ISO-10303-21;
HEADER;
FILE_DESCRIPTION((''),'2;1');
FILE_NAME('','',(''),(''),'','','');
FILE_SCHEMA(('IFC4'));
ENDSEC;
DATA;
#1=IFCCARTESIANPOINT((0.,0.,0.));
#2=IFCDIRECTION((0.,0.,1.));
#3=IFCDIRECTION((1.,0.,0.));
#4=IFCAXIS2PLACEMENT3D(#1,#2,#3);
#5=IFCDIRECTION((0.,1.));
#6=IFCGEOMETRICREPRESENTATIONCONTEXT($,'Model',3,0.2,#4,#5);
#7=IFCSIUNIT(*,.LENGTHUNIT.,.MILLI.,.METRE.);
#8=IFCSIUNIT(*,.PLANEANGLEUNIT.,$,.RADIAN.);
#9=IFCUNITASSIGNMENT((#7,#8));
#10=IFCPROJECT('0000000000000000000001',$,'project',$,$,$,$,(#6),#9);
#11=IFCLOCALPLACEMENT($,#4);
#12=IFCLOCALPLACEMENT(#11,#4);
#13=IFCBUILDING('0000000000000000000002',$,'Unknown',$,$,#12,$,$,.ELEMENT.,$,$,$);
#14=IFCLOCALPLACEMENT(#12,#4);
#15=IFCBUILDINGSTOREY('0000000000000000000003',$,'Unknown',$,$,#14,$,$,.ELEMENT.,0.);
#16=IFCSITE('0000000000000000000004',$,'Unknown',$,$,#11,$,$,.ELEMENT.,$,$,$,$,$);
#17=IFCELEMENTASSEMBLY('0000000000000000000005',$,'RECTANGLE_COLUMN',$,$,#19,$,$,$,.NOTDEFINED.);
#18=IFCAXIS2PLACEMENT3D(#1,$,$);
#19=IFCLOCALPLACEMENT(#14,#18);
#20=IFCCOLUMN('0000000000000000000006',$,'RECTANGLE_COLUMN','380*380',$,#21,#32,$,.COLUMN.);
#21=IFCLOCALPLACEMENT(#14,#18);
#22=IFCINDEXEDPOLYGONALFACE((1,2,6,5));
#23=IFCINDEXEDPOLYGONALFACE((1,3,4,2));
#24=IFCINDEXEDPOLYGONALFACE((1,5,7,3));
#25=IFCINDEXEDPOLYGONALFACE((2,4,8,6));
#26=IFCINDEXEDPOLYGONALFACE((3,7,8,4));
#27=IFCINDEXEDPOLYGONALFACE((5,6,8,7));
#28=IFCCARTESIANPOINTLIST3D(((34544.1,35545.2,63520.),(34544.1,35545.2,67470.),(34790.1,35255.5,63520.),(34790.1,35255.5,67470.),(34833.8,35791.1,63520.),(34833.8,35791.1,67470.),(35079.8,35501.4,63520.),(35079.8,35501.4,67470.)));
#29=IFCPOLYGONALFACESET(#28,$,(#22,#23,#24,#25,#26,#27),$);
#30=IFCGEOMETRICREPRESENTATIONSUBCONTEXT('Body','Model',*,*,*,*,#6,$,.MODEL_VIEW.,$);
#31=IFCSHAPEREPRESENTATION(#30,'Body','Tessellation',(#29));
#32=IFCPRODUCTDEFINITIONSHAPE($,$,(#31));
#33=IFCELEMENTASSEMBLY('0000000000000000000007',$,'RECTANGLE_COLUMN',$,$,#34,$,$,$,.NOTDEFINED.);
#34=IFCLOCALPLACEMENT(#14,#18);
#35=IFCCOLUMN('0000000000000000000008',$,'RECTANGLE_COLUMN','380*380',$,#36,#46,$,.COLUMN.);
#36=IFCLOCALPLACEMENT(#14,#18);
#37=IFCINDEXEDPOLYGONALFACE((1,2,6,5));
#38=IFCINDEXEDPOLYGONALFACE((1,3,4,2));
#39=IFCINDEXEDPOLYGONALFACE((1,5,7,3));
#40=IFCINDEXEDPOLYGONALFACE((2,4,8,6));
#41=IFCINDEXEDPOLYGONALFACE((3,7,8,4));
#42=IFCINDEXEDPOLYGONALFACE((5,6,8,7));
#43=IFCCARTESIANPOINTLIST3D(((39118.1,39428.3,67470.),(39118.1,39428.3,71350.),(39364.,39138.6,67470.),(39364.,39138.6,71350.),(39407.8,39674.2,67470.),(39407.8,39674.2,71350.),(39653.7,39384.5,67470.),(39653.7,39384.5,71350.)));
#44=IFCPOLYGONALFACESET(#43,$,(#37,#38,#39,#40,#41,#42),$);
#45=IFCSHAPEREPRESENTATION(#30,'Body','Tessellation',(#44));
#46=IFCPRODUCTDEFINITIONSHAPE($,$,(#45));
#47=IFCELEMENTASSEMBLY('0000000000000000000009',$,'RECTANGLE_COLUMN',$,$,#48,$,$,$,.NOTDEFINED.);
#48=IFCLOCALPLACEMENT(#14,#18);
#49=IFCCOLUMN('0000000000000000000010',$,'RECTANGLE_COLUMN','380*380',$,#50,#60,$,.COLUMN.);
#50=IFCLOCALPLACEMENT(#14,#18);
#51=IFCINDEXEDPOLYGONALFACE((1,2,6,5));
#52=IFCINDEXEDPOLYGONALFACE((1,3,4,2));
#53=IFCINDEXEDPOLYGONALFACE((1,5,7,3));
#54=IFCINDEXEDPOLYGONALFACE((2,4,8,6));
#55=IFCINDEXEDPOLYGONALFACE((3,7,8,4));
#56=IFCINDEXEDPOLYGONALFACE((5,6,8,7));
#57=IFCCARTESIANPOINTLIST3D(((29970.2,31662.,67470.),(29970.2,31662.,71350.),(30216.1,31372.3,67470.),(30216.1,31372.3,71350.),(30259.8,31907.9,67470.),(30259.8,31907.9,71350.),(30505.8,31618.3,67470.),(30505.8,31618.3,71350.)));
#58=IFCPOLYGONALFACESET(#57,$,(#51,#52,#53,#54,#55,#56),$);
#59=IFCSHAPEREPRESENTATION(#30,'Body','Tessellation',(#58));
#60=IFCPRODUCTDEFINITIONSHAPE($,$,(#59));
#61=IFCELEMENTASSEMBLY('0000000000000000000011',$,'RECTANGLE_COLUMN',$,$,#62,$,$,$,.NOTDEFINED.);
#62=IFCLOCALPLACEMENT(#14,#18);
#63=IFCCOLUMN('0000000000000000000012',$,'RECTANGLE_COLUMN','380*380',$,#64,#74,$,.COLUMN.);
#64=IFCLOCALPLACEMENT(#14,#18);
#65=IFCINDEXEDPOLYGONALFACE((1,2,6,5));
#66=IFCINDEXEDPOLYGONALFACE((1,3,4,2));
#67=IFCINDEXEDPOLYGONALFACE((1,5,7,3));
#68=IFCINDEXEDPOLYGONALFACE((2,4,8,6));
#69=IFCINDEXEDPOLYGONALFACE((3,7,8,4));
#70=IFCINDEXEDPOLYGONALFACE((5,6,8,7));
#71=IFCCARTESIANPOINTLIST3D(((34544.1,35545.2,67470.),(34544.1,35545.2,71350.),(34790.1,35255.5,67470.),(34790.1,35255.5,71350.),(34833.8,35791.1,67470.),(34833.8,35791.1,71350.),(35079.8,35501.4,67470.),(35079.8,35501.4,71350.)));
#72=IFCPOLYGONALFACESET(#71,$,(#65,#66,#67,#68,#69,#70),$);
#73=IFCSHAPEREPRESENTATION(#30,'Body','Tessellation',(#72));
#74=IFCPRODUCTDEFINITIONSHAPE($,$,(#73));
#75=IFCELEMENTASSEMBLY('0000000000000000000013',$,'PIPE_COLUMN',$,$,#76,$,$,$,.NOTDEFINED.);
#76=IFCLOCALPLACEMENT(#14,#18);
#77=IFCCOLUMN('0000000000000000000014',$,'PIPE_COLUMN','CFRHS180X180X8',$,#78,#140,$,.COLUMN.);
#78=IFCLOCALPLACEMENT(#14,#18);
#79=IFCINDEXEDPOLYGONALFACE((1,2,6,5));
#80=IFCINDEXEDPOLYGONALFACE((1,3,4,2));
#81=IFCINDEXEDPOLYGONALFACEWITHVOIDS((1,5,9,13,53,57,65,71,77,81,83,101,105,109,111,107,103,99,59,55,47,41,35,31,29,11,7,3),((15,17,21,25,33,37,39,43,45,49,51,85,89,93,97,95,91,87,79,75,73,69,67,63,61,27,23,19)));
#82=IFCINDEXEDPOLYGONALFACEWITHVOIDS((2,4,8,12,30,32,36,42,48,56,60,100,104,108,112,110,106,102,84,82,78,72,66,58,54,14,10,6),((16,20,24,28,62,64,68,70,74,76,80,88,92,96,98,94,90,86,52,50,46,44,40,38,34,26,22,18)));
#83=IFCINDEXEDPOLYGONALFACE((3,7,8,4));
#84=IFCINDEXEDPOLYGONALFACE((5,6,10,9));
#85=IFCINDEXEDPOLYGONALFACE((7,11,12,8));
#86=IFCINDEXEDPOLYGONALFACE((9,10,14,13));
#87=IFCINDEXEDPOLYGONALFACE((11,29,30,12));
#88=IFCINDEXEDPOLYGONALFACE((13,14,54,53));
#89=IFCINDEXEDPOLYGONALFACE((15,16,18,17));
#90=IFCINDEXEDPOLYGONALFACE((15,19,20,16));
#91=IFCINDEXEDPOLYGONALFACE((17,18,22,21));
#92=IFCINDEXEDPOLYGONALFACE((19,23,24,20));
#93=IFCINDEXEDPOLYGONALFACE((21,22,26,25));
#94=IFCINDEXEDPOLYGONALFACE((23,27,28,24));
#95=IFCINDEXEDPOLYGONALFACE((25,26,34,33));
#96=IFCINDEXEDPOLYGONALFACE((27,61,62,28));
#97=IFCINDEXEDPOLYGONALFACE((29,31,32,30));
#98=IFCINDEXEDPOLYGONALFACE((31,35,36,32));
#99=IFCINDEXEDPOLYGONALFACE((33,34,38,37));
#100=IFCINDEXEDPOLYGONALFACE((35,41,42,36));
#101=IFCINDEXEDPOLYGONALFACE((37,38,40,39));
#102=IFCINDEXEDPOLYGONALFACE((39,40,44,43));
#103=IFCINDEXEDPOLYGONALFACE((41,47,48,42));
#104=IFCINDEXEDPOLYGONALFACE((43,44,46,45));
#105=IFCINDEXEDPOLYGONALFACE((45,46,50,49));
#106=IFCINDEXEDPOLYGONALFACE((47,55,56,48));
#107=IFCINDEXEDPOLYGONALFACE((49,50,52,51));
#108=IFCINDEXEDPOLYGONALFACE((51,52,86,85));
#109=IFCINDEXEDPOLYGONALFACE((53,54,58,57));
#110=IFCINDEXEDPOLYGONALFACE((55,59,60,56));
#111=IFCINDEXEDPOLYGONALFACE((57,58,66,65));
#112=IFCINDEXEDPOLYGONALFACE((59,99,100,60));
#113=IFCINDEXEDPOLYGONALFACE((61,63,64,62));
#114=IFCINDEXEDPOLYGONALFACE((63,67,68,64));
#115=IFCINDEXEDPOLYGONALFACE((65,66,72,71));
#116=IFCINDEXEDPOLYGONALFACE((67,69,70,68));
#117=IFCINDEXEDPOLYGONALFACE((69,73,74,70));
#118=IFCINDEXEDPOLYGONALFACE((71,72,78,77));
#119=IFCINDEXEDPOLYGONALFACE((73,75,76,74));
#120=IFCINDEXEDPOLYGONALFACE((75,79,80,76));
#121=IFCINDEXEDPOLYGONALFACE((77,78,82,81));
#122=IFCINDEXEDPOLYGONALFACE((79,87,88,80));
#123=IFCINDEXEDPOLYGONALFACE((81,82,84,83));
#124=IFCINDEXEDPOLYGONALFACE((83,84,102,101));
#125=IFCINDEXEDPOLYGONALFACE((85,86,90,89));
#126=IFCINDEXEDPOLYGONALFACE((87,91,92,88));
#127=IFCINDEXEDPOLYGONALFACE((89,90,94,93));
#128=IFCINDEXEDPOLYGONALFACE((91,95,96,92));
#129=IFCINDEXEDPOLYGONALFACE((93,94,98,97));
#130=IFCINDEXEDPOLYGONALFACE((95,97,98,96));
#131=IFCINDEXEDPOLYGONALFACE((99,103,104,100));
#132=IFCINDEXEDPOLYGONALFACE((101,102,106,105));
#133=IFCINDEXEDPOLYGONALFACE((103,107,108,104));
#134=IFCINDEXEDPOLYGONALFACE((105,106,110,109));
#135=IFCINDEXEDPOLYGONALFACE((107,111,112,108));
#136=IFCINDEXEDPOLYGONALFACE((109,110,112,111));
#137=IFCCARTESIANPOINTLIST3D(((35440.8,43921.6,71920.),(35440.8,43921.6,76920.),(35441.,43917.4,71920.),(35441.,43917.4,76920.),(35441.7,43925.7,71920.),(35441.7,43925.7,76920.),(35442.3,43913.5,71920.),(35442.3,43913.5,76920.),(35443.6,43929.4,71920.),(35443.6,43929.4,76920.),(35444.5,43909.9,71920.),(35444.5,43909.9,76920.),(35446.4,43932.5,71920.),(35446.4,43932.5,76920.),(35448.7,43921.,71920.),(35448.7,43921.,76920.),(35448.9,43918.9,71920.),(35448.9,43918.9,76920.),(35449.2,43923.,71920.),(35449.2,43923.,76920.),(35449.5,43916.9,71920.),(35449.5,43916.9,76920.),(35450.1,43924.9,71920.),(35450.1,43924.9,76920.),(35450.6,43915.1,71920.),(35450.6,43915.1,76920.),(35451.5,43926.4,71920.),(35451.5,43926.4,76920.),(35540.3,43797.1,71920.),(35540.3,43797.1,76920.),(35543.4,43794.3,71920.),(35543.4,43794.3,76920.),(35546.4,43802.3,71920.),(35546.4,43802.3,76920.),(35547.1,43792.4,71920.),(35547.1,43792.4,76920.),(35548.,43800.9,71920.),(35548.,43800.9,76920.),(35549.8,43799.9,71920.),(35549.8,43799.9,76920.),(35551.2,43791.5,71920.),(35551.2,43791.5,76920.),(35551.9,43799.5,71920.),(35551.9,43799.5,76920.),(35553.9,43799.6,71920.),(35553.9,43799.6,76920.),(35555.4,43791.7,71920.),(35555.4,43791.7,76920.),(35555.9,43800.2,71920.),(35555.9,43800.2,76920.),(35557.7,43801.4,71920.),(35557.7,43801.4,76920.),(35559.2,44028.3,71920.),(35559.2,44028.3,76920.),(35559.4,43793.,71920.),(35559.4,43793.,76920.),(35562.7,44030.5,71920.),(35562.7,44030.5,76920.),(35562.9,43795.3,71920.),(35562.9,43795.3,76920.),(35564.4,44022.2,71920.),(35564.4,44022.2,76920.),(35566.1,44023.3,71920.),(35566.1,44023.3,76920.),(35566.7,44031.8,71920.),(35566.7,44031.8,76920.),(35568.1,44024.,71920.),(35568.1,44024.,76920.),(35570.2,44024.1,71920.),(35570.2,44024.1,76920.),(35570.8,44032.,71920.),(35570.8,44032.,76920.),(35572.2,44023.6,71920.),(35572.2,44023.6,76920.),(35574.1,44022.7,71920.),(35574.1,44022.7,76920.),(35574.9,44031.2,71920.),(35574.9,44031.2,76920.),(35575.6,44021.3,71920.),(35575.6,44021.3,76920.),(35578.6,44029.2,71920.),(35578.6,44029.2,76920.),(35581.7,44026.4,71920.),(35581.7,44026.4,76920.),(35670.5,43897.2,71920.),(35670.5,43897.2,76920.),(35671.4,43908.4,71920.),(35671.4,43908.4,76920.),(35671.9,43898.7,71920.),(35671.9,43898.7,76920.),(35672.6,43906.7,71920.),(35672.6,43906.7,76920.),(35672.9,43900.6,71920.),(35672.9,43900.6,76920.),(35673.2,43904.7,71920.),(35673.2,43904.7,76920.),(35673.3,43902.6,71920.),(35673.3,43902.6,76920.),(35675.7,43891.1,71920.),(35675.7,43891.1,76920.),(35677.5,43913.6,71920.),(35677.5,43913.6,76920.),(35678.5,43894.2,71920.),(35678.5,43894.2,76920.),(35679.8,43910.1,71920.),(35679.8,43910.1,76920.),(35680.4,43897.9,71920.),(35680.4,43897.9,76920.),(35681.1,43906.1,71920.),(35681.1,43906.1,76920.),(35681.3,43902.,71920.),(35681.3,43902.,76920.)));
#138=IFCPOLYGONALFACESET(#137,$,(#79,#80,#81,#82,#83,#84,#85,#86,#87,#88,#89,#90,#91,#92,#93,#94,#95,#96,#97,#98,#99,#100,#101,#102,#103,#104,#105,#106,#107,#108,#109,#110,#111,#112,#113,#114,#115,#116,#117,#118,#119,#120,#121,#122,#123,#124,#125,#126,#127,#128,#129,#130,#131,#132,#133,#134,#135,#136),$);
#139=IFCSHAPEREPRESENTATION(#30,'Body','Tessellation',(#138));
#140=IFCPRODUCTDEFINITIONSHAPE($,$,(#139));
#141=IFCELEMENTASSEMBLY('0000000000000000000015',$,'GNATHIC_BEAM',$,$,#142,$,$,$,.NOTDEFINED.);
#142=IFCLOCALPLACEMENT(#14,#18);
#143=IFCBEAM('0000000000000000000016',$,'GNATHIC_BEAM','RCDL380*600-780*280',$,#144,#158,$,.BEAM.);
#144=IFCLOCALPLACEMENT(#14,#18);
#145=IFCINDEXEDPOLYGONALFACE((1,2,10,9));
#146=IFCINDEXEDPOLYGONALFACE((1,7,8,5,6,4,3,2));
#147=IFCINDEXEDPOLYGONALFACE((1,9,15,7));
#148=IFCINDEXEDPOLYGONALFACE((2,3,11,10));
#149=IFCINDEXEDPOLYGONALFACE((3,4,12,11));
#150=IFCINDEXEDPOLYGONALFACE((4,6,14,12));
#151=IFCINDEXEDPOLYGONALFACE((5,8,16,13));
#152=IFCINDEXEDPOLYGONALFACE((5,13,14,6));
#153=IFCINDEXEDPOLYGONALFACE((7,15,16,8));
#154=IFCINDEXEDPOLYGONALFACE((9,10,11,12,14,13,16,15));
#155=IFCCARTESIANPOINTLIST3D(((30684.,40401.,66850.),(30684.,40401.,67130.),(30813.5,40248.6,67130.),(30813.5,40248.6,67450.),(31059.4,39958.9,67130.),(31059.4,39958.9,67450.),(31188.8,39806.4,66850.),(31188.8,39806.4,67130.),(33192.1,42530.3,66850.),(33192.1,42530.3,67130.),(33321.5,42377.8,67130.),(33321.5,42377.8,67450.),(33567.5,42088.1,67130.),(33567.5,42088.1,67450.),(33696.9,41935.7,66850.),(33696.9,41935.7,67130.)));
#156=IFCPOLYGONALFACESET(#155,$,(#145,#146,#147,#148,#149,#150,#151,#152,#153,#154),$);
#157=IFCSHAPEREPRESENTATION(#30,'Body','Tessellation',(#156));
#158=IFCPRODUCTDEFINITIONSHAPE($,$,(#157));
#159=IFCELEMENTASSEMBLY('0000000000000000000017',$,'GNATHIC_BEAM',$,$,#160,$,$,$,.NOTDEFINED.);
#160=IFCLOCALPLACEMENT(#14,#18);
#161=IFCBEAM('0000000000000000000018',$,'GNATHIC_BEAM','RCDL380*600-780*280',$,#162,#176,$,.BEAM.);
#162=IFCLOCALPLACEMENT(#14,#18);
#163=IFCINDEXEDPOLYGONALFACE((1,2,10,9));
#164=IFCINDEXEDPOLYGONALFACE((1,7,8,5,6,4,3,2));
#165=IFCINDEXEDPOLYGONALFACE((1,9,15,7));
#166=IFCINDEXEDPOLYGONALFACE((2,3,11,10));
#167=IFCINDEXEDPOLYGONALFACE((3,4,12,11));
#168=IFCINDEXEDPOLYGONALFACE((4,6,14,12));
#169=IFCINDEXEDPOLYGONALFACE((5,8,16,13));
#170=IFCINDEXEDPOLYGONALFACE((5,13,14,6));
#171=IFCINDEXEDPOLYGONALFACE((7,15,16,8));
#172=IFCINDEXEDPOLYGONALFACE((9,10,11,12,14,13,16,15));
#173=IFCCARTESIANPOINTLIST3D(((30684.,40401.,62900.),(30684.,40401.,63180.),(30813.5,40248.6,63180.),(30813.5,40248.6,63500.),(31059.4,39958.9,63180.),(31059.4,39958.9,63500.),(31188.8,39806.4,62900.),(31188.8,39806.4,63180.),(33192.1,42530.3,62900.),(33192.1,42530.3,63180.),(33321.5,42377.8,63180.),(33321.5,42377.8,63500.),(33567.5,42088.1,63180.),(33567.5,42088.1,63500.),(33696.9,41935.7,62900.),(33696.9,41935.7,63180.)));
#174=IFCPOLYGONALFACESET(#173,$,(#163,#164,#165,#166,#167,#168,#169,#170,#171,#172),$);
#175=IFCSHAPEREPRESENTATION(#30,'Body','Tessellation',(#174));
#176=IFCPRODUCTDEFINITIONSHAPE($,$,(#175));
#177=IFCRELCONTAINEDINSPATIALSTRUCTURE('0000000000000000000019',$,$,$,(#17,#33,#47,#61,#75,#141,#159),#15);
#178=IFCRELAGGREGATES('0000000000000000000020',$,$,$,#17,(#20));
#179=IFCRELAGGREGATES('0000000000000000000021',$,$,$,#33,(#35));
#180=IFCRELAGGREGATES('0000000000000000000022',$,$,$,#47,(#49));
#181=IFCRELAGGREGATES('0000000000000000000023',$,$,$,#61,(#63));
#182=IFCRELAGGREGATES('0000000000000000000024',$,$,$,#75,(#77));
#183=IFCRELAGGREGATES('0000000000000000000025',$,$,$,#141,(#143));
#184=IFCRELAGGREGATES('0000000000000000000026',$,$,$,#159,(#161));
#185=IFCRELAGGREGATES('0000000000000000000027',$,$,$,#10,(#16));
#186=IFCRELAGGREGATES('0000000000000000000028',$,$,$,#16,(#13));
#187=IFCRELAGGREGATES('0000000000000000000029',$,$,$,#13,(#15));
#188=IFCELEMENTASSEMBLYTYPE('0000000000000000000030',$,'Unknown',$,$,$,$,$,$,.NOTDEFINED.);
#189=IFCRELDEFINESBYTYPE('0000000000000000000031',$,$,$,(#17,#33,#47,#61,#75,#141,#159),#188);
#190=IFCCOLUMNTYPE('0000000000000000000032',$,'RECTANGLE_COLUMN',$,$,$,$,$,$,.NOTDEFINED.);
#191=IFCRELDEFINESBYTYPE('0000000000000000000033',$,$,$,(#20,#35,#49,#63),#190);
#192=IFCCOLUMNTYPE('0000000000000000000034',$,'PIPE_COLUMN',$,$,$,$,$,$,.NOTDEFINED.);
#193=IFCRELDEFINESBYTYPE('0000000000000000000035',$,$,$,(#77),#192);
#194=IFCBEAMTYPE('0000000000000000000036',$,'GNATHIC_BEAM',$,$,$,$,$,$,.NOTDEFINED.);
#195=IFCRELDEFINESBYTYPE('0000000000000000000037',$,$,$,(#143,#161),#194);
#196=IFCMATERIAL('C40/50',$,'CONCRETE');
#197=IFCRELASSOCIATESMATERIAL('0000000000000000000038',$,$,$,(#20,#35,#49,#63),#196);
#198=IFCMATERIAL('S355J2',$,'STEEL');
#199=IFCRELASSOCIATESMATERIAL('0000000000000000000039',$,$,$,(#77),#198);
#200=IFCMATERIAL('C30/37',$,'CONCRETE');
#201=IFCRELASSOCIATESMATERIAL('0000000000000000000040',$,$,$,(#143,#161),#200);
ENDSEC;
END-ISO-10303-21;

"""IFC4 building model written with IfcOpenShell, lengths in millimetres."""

from ifc_helpers import new_model, si_unit, direction, frame, origin_with_axes, origin_2d_with_axis, place, context, subcontext, project, spatial, polyline, rectangle, hollow_rectangle, outline, extrude, material, material_profile, profile_set, profile_usage, type_object, element, aggregate, save


model = new_model("IFC4")

# Units and contexts
model_context = context("Model", 3, precision=0.2, world=origin_with_axes(), true_north=direction((0.0, 1.0)))
body_context = subcontext(model_context, "Body", "Model", "MODEL_VIEW")
ifc_project = project(units=[si_unit("LENGTHUNIT", "METRE", prefix="MILLI"), si_unit("PLANEANGLEUNIT", "RADIAN")], contexts=[model_context])

# Site, building, storey
site_placement = place(None, origin_with_axes())
site = spatial("IfcSite", under=ifc_project, at=site_placement, Name="Unknown", CompositionType="ELEMENT")
building_placement = place(site_placement, origin_with_axes())
building = spatial("IfcBuilding", under=site, at=building_placement, Name="Unknown", CompositionType="ELEMENT")
storey_placement = place(building_placement, origin_with_axes())
storey = spatial("IfcBuildingStorey", under=building, at=storey_placement, Name="Unknown", CompositionType="ELEMENT", Elevation=0.0)

# Element assemblies, columns
element_assembly_type = type_object("IfcElementAssemblyType", Name="Unknown", PredefinedType="NOTDEFINED")
assembly_1_placement = place(storey_placement, frame((34811.9, 35523.3, 63520.0), z_axis=(-0.762329, -0.64719, 0.0), x_axis=(0.0, 0.0, 1.0)))
assembly_1 = element("IfcElementAssembly", 1, at=assembly_1_placement, inside=storey, type_object=element_assembly_type, Name="RECTANGLE_COLUMN", PredefinedType="NOTDEFINED")
ifc_material_1 = material(Name="C40/50", Category="CONCRETE")
ifc_material_profile_1 = material_profile(ifc_material_1, rectangle(XDim=380.0, YDim=380.0, at=origin_2d_with_axis()), Name="380*380")
ifc_profile_set_1 = profile_set([ifc_material_profile_1])
ifc_profile_usage_1 = profile_usage(ifc_profile_set_1, cardinal=5)
column_type_1 = type_object("IfcColumnType", Name="RECTANGLE_COLUMN")
column_1_placement = place(assembly_1_placement, origin_with_axes())
column_1 = element("IfcColumn", 2, at=column_1_placement, type_object=column_type_1, material=ifc_profile_usage_1, Name="RECTANGLE_COLUMN", Description="380*380", PredefinedType="COLUMN", context=body_context, shape_type="SolidModel", body=[
    extrude(rectangle(XDim=380.0, YDim=380.0, at=origin_2d_with_axis()), frame((0.0, 0.0, 0.0), z_axis=(-1.0, 0.0, 0.0), x_axis=(0.0, 0.0, 1.0)), (0.0, 0.0, -1.0), 3950.0),
])
aggregate(assembly_1, [column_1])
assembly_2_placement = place(storey_placement, frame((39385.9, 39406.4, 67470.0), z_axis=(-0.762329, -0.64719, 0.0), x_axis=(0.0, 0.0, 1.0)))
assembly_2 = element("IfcElementAssembly", 3, at=assembly_2_placement, inside=storey, type_object=element_assembly_type, Name="RECTANGLE_COLUMN", PredefinedType="NOTDEFINED")
column_2_placement = place(assembly_2_placement, origin_with_axes())
column_2 = element("IfcColumn", 4, at=column_2_placement, type_object=column_type_1, material=ifc_profile_usage_1, Name="RECTANGLE_COLUMN", Description="380*380", PredefinedType="COLUMN", context=body_context, shape_type="SolidModel", body=[
    extrude(rectangle(XDim=380.0, YDim=380.0, at=origin_2d_with_axis()), frame((0.0, 0.0, 0.0), z_axis=(-1.0, 0.0, 0.0), x_axis=(0.0, 0.0, 1.0)), (0.0, 0.0, -1.0), 3880.0),
])
aggregate(assembly_2, [column_2])
assembly_3_placement = place(storey_placement, frame((30238.0, 31640.1, 67470.0), z_axis=(-0.762329, -0.64719, 0.0), x_axis=(0.0, 0.0, 1.0)))
assembly_3 = element("IfcElementAssembly", 5, at=assembly_3_placement, inside=storey, type_object=element_assembly_type, Name="RECTANGLE_COLUMN", PredefinedType="NOTDEFINED")
column_3_placement = place(assembly_3_placement, origin_with_axes())
column_3 = element("IfcColumn", 6, at=column_3_placement, type_object=column_type_1, material=ifc_profile_usage_1, Name="RECTANGLE_COLUMN", Description="380*380", PredefinedType="COLUMN", context=body_context, shape_type="SolidModel", body=[
    extrude(rectangle(XDim=380.0, YDim=380.0, at=origin_2d_with_axis()), frame((0.0, 0.0, 0.0), z_axis=(-1.0, 0.0, 0.0), x_axis=(0.0, 0.0, 1.0)), (0.0, 0.0, -1.0), 3880.0),
])
aggregate(assembly_3, [column_3])
assembly_4_placement = place(storey_placement, frame((34811.9, 35523.3, 67470.0), z_axis=(-0.762329, -0.64719, 0.0), x_axis=(0.0, 0.0, 1.0)))
assembly_4 = element("IfcElementAssembly", 7, at=assembly_4_placement, inside=storey, type_object=element_assembly_type, Name="RECTANGLE_COLUMN", PredefinedType="NOTDEFINED")
column_4_placement = place(assembly_4_placement, origin_with_axes())
column_4 = element("IfcColumn", 8, at=column_4_placement, type_object=column_type_1, material=ifc_profile_usage_1, Name="RECTANGLE_COLUMN", Description="380*380", PredefinedType="COLUMN", context=body_context, shape_type="SolidModel", body=[
    extrude(rectangle(XDim=380.0, YDim=380.0, at=origin_2d_with_axis()), frame((0.0, 0.0, 0.0), z_axis=(-1.0, 0.0, 0.0), x_axis=(0.0, 0.0, 1.0)), (0.0, 0.0, -1.0), 3880.0),
])
aggregate(assembly_4, [column_4])
assembly_5_placement = place(storey_placement, frame((35561.0, 43911.8, 71920.0), z_axis=(-0.762329, -0.64719, 0.0), x_axis=(0.0, 0.0, 1.0)))
assembly_5 = element("IfcElementAssembly", 9, at=assembly_5_placement, inside=storey, type_object=element_assembly_type, Name="PIPE_COLUMN", PredefinedType="NOTDEFINED")
ifc_material_2 = material(Name="S355J2", Category="STEEL")
ifc_material_profile_2 = material_profile(ifc_material_2, hollow_rectangle(XDim=180.0, YDim=180.0, WallThickness=8.0, InnerFilletRadius=8.0, OuterFilletRadius=16.0, at=origin_2d_with_axis()), Name="CFRHS180X180X8")
ifc_profile_set_2 = profile_set([ifc_material_profile_2])
ifc_profile_usage_2 = profile_usage(ifc_profile_set_2, cardinal=4)
column_type_2 = type_object("IfcColumnType", Name="PIPE_COLUMN")
column_5_placement = place(assembly_5_placement, origin_with_axes())
column_5 = element("IfcColumn", 10, at=column_5_placement, type_object=column_type_2, material=ifc_profile_usage_2, Name="PIPE_COLUMN", Description="CFRHS180X180X8", PredefinedType="COLUMN", context=body_context, shape_type="SolidModel", body=[
    extrude(hollow_rectangle(XDim=180.0, YDim=180.0, WallThickness=8.0, InnerFilletRadius=8.0, OuterFilletRadius=16.0, at=origin_2d_with_axis()), frame((0.0, 0.0, 0.0), z_axis=(-1.0, 0.0, 0.0), x_axis=(0.0, 0.0, 1.0)), (0.0, 0.0, -1.0), 5000.0),
])
aggregate(assembly_5, [column_5])

# Element assemblies, beams
assembly_6_placement = place(storey_placement, frame((30936.4, 40103.7, 67150.0), z_axis=(0.64719, -0.762329, 0.0), x_axis=(0.762329, 0.64719, 0.0)))
assembly_6 = element("IfcElementAssembly", 11, at=assembly_6_placement, inside=storey, type_object=element_assembly_type, Name="GNATHIC_BEAM", PredefinedType="NOTDEFINED")
ifc_material_3 = material(Name="C30/37", Category="CONCRETE")
ifc_material_profile_3 = material_profile(ifc_material_3, outline(polyline([(-390.0, -300.0), (390.0, -300.0), (390.0, -20.0), (190.0, -20.0), (190.0, 300.0), (-190.0, 300.0), (-190.0, -20.0), (-390.0, -20.0), (-390.0, -300.0)])), Name="RCDL380*600-780*280")
ifc_profile_set_3 = profile_set([ifc_material_profile_3])
ifc_profile_usage_3 = profile_usage(ifc_profile_set_3, cardinal=2)
beam_type_1 = type_object("IfcBeamType", Name="GNATHIC_BEAM")
beam_1_placement = place(assembly_6_placement, origin_with_axes())
beam_1 = element("IfcBeam", 12, at=beam_1_placement, type_object=beam_type_1, material=ifc_profile_usage_3, Name="GNATHIC_BEAM", Description="RCDL380*600-780*280", PredefinedType="BEAM", context=body_context, shape_type="SolidModel", body=[
    extrude(outline(polyline([(-390.0, -300.0), (390.0, -300.0), (390.0, -20.0), (190.0, -20.0), (190.0, 300.0), (-190.0, 300.0), (-190.0, -20.0), (-390.0, -20.0), (-390.0, -300.0)])), frame((0.0, 0.0, 0.0), z_axis=(-1.0, 0.0, 0.0), x_axis=(0.0, 0.0, 1.0)), (0.0, 0.0, -1.0), 3290.0),
])
aggregate(assembly_6, [beam_1])
assembly_7_placement = place(storey_placement, frame((30936.4, 40103.7, 63200.0), z_axis=(0.64719, -0.762329, 0.0), x_axis=(0.762329, 0.64719, 0.0)))
assembly_7 = element("IfcElementAssembly", 13, at=assembly_7_placement, inside=storey, type_object=element_assembly_type, Name="GNATHIC_BEAM", PredefinedType="NOTDEFINED")
beam_2_placement = place(assembly_7_placement, origin_with_axes())
beam_2 = element("IfcBeam", 14, at=beam_2_placement, type_object=beam_type_1, material=ifc_profile_usage_3, Name="GNATHIC_BEAM", Description="RCDL380*600-780*280", PredefinedType="BEAM", context=body_context, shape_type="SolidModel", body=[
    extrude(outline(polyline([(-390.0, -300.0), (390.0, -300.0), (390.0, -20.0), (190.0, -20.0), (190.0, 300.0), (-190.0, 300.0), (-190.0, -20.0), (-390.0, -20.0), (-390.0, -300.0)])), frame((0.0, 0.0, 0.0), z_axis=(-1.0, 0.0, 0.0), x_axis=(0.0, 0.0, 1.0)), (0.0, 0.0, -1.0), 3290.0),
])
aggregate(assembly_7, [beam_2])

save(model, "model.ifc")
